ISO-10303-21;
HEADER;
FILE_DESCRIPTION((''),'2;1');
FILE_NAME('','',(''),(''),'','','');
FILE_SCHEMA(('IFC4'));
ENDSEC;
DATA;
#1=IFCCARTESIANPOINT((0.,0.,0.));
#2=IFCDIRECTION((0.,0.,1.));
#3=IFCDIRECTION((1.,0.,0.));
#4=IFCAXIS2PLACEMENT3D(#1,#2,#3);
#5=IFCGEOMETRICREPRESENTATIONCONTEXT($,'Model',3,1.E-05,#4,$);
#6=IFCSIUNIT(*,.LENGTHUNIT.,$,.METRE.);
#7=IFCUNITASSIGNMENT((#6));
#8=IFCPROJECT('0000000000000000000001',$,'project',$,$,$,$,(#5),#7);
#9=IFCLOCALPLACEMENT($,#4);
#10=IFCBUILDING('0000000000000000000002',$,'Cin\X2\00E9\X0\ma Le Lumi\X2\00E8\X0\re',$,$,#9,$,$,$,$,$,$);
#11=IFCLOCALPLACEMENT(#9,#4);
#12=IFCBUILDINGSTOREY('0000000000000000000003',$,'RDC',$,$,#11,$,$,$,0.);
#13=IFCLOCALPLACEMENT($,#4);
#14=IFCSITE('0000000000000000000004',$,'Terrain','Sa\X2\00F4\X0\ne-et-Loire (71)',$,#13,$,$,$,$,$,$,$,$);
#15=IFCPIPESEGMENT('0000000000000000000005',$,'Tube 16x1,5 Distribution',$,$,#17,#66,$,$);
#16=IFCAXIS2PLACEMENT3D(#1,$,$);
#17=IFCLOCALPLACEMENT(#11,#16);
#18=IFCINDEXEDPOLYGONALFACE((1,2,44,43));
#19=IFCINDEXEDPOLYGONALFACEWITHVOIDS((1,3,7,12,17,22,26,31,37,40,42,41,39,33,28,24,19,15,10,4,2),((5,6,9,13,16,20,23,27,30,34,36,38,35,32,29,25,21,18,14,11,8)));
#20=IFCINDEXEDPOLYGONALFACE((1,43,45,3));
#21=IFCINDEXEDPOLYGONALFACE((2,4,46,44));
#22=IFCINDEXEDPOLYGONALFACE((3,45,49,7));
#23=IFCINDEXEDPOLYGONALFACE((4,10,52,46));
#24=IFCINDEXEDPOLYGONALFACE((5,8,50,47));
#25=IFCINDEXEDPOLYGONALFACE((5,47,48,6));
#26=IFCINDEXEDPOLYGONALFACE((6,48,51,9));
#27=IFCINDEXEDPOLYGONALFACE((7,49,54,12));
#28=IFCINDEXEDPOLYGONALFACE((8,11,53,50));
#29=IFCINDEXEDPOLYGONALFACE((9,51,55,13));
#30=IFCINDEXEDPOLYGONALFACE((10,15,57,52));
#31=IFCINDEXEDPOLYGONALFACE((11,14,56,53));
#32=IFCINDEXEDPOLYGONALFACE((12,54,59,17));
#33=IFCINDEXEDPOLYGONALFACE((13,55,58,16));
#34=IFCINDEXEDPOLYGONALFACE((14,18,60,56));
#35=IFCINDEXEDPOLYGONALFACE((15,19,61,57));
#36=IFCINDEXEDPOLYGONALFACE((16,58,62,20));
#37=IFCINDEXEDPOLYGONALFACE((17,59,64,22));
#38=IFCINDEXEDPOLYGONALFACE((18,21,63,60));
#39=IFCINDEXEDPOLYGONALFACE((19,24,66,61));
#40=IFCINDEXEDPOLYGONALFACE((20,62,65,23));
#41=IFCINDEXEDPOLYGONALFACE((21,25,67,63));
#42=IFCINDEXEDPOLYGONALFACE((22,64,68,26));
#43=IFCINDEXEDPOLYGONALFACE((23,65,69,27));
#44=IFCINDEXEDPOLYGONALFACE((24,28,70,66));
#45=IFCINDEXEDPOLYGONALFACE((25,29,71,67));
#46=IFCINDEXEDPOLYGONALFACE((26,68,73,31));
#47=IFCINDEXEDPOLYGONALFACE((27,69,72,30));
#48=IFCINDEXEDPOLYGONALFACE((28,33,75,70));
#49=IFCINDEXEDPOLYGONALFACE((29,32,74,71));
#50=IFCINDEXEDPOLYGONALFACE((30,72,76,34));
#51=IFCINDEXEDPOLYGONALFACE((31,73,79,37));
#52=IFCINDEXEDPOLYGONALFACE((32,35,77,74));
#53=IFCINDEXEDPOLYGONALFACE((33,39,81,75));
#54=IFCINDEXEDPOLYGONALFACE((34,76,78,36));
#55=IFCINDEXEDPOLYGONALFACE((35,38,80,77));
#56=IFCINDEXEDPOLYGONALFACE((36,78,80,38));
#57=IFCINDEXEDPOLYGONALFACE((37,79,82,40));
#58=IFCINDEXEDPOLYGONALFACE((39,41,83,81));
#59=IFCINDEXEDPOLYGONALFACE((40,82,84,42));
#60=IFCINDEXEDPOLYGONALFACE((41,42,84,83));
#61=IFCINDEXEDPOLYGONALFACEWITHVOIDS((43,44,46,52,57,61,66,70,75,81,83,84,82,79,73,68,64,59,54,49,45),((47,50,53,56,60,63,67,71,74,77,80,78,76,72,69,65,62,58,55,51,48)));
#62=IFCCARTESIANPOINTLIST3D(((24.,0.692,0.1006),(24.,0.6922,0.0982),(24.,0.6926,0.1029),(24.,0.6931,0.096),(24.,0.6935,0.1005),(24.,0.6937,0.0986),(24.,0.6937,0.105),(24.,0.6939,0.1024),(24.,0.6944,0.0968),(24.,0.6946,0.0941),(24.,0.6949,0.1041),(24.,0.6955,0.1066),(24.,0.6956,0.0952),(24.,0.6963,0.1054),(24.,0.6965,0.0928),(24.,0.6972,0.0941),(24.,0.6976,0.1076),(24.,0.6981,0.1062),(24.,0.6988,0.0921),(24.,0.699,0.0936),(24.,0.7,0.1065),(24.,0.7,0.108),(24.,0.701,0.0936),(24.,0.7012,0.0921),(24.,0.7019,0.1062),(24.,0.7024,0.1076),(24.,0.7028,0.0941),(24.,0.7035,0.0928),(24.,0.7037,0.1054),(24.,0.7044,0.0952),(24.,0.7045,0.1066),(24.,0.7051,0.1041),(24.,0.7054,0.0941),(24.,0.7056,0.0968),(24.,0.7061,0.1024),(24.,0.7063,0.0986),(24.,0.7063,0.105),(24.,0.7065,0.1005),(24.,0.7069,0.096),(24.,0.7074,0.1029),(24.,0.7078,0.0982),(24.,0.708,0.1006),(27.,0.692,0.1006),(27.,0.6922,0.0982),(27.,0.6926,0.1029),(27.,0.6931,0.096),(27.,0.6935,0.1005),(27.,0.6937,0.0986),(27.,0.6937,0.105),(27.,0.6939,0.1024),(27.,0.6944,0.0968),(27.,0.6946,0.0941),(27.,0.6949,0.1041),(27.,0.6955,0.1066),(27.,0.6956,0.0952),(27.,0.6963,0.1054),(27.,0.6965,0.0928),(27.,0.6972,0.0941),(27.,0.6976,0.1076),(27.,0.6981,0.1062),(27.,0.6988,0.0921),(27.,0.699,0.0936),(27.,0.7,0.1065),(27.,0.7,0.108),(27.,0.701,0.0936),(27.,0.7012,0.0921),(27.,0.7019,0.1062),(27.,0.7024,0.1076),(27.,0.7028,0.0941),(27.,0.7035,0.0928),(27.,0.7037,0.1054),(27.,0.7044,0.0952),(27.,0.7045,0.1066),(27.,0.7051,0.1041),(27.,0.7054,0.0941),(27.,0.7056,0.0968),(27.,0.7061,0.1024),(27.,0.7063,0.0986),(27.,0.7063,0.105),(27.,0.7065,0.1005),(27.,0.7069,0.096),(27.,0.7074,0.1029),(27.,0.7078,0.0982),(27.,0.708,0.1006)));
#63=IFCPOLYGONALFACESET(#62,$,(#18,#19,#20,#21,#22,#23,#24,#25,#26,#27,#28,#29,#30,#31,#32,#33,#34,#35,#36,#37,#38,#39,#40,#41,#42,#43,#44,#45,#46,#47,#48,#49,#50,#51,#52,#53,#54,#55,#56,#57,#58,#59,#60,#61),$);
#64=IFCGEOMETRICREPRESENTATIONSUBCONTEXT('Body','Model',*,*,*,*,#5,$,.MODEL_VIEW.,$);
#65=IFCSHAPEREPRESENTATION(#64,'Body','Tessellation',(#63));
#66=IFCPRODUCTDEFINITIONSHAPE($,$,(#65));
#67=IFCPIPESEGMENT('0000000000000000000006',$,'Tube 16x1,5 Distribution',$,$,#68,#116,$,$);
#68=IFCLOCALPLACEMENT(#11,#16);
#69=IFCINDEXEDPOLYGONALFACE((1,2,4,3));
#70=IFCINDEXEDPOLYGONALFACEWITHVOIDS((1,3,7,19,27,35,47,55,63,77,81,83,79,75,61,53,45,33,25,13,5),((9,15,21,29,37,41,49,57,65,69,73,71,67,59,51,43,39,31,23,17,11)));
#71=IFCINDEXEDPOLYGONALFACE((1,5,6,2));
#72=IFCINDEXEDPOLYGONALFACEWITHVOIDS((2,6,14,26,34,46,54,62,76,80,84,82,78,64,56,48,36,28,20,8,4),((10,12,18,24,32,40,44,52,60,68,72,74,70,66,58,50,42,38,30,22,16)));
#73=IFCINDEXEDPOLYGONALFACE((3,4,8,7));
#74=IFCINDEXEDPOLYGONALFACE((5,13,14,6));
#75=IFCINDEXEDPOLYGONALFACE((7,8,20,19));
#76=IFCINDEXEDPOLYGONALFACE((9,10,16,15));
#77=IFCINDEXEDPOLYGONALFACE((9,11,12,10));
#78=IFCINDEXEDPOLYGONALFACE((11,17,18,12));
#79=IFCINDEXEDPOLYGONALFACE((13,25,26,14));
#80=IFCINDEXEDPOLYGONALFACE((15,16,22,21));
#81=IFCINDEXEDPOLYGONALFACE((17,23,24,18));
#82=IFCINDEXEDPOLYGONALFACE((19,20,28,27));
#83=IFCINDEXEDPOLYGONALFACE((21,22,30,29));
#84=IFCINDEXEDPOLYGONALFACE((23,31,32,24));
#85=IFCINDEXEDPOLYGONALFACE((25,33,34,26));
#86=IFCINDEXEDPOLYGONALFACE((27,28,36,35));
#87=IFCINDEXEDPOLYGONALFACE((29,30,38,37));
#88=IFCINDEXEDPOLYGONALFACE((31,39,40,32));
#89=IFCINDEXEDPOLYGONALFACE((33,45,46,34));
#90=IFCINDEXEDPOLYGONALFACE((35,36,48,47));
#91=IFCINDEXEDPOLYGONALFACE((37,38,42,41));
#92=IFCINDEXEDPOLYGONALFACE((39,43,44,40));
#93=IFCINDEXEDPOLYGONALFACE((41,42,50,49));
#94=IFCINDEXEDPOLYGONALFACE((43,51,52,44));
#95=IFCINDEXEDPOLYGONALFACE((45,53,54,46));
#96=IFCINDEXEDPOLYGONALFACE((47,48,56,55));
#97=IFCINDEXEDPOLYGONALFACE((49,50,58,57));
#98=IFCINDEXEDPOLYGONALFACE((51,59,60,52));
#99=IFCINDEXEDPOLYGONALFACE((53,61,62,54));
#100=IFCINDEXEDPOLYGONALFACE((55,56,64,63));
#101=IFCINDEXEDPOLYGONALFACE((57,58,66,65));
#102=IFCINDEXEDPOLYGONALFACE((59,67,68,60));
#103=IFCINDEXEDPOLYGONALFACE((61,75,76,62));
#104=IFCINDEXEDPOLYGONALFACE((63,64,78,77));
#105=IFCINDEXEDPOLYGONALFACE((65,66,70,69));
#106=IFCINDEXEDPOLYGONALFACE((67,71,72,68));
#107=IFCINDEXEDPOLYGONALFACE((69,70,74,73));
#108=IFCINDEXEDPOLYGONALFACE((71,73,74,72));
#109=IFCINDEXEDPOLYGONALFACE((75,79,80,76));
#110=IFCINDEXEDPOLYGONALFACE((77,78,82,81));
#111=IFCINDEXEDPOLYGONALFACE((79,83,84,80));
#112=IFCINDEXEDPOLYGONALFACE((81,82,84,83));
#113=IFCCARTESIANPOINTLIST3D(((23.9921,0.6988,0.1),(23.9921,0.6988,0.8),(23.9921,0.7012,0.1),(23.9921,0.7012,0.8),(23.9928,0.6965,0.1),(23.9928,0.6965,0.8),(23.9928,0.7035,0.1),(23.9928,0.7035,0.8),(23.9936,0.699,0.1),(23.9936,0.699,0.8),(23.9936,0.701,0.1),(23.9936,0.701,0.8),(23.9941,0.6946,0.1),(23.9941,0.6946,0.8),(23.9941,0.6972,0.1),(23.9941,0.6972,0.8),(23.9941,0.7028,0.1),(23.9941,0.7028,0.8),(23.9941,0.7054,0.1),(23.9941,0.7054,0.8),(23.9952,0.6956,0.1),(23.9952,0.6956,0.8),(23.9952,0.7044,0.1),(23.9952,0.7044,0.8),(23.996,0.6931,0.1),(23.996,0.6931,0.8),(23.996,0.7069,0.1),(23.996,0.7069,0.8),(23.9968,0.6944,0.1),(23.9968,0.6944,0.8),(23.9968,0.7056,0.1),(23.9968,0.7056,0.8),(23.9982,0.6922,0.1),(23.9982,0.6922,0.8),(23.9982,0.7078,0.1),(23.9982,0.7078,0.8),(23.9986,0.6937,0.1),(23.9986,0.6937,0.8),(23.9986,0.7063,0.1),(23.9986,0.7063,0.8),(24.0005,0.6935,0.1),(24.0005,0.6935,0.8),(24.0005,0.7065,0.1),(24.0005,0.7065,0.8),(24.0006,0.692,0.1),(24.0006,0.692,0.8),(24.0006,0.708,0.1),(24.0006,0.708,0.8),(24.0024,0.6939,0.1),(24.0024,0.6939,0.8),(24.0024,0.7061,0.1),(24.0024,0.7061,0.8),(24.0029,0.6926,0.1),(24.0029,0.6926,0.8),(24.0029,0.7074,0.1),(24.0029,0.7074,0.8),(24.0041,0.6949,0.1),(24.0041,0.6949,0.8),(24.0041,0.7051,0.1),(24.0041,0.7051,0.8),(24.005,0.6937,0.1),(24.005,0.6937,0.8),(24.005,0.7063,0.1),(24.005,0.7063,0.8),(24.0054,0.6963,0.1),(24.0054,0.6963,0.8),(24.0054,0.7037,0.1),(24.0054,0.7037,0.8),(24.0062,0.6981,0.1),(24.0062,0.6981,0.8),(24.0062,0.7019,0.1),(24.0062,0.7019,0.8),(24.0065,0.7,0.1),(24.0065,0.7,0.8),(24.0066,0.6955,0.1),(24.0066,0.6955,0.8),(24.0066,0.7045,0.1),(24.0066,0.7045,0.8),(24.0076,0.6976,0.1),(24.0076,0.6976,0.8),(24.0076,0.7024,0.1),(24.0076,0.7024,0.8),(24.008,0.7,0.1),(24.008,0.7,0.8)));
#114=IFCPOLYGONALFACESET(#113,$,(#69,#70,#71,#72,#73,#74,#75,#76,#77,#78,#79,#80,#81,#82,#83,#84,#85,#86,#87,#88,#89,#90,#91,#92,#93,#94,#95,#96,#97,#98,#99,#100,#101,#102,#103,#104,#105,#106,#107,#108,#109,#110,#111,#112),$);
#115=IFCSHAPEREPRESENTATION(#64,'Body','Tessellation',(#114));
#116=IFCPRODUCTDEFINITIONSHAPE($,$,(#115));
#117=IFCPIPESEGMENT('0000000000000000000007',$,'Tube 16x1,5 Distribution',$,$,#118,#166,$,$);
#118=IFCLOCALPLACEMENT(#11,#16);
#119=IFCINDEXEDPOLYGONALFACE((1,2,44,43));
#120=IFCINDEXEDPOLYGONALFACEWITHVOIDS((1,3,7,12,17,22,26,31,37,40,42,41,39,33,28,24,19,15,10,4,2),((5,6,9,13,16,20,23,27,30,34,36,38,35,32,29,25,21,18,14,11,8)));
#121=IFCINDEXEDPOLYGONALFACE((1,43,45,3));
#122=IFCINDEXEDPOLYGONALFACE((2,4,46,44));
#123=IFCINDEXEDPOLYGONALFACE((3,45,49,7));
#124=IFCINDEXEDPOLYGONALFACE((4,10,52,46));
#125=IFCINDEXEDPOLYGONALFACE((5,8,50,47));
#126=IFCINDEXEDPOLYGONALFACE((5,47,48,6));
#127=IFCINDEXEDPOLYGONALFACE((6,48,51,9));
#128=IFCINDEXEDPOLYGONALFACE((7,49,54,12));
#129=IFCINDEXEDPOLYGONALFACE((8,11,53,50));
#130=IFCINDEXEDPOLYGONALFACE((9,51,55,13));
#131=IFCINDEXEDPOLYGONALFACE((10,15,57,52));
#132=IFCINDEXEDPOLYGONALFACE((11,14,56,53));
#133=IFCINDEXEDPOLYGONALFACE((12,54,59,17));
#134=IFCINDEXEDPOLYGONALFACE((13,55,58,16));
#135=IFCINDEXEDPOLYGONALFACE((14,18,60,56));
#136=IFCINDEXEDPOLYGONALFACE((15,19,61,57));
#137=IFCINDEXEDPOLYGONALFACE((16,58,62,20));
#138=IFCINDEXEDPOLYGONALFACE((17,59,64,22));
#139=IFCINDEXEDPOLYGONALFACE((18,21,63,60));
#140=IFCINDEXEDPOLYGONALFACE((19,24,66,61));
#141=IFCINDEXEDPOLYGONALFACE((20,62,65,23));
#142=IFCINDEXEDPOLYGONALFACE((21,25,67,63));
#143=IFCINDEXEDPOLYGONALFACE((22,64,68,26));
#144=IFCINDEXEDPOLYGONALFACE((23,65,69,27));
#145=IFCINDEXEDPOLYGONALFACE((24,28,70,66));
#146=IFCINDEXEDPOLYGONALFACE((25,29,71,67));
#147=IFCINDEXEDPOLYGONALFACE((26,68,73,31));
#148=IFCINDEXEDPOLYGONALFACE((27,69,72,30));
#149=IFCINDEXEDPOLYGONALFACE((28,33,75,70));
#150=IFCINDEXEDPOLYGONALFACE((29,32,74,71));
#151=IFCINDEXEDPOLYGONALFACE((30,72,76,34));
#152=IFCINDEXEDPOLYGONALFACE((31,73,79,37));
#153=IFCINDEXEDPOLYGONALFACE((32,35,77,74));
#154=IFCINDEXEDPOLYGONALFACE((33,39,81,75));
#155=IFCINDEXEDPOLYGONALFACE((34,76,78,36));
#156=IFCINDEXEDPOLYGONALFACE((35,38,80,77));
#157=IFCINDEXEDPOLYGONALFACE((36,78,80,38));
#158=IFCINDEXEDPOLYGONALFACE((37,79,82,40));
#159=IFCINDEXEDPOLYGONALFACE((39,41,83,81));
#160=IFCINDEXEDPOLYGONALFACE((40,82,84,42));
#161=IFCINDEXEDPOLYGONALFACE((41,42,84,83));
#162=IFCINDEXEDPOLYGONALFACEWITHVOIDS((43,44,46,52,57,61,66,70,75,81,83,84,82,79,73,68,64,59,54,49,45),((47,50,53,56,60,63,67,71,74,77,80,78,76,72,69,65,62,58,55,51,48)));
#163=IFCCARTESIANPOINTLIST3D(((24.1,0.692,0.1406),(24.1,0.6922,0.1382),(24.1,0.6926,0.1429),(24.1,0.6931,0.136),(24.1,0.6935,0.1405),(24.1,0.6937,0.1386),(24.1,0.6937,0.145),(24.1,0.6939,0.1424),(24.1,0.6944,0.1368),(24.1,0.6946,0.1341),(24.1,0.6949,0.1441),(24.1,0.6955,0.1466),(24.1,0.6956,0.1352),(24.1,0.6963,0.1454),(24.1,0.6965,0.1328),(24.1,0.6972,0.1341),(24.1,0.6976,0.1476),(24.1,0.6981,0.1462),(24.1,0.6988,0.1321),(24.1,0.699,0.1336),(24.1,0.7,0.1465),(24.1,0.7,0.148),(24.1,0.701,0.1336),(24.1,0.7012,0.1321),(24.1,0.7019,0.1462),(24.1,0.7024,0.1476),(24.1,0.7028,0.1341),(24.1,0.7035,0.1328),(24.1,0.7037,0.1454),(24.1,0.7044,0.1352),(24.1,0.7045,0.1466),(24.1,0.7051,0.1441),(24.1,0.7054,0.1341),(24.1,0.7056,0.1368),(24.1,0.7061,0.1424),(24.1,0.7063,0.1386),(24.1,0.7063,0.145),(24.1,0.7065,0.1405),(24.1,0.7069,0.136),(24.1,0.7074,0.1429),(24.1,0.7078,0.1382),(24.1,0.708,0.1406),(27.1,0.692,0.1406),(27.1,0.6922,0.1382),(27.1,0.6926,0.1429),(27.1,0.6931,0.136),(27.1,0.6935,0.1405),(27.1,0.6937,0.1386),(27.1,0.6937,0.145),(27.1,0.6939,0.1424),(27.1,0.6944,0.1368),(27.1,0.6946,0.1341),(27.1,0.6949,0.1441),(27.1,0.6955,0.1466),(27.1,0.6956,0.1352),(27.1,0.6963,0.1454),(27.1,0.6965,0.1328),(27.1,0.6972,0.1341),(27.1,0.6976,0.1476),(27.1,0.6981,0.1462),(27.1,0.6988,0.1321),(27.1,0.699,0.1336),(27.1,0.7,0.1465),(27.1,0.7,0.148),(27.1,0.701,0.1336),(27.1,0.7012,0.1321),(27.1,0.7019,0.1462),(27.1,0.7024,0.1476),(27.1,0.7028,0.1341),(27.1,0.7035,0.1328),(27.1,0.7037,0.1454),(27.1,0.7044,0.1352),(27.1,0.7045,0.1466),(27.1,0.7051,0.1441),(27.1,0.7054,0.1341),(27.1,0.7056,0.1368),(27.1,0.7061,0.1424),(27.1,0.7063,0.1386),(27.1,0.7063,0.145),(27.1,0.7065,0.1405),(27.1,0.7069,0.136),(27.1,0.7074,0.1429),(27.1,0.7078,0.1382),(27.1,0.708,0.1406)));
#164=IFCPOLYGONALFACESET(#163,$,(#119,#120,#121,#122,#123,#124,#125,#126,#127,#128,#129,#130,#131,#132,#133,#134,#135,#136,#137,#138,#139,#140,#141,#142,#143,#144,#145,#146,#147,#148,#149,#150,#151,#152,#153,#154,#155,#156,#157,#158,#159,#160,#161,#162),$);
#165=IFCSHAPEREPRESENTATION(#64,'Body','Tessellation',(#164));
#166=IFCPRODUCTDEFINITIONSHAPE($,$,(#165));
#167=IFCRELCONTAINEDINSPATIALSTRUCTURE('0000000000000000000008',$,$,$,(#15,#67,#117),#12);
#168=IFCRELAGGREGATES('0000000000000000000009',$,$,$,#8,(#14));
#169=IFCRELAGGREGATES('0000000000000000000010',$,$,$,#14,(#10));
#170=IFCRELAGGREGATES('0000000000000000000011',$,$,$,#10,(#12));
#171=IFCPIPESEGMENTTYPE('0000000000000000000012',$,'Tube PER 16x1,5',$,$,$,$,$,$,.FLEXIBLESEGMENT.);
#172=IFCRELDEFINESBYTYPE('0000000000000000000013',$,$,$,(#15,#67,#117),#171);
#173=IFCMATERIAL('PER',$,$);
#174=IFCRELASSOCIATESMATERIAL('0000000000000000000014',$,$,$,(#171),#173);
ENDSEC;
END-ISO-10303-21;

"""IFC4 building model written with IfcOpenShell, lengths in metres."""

from ifc_helpers import new_model, si_unit, frame, origin_with_axes, place, context, subcontext, project, spatial, hollow_circle, extrude, material, type_object, element, save


model = new_model("IFC4")

# Units and contexts
model_context = context("Model", 3, precision=1e-05, world=origin_with_axes())
body_context = subcontext(model_context, "Body", "Model", "MODEL_VIEW")
ifc_project = project(units=[si_unit("LENGTHUNIT", "METRE")], contexts=[model_context])

# Site, building, storey
site_placement = place(None, origin_with_axes())
site = spatial("IfcSite", under=ifc_project, at=site_placement, Name="Terrain", Description="Saône-et-Loire (71)")
building_placement = place(None, origin_with_axes())
building = spatial("IfcBuilding", under=site, at=building_placement, Name="Cinéma Le Lumière")
storey_placement = place(building_placement, origin_with_axes())
storey = spatial("IfcBuildingStorey", under=building, at=storey_placement, Name="RDC", Elevation=0.0)

# Pipe segments
ifc_material_1 = material(Name="PER")
pipe_segment_type_1 = type_object("IfcPipeSegmentType", Name="Tube PER 16x1,5", PredefinedType="FLEXIBLESEGMENT", material=ifc_material_1)
pipe_segment_1_placement = place(storey_placement, frame((27.0, 0.7, 0.1), z_axis=(-1.0, 0.0, 0.0), x_axis=(0.0, 0.0, 1.0)))
element("IfcPipeSegment", 1, at=pipe_segment_1_placement, inside=storey, type_object=pipe_segment_type_1, Name="Tube 16x1,5 Distribution", context=body_context, shape_type="SweptSolid", body=[
    extrude(hollow_circle(Radius=0.008, WallThickness=0.0015), origin_with_axes(), (0.0, 0.0, 1.0), 3.0),
])
pipe_segment_2_placement = place(storey_placement, frame((24.0, 0.7, 0.1), z_axis=(0.0, 0.0, 1.0), x_axis=(1.0, 0.0, 0.0)))
element("IfcPipeSegment", 2, at=pipe_segment_2_placement, inside=storey, type_object=pipe_segment_type_1, Name="Tube 16x1,5 Distribution", context=body_context, shape_type="SweptSolid", body=[
    extrude(hollow_circle(Radius=0.008, WallThickness=0.0015), origin_with_axes(), (0.0, 0.0, 1.0), 0.7),
])
pipe_segment_3_placement = place(storey_placement, frame((27.1, 0.7, 0.14), z_axis=(-1.0, 0.0, 0.0), x_axis=(0.0, 0.0, 1.0)))
element("IfcPipeSegment", 3, at=pipe_segment_3_placement, inside=storey, type_object=pipe_segment_type_1, Name="Tube 16x1,5 Distribution", context=body_context, shape_type="SweptSolid", body=[
    extrude(hollow_circle(Radius=0.008, WallThickness=0.0015), origin_with_axes(), (0.0, 0.0, 1.0), 3.0),
])

save(model, "model.ifc")
